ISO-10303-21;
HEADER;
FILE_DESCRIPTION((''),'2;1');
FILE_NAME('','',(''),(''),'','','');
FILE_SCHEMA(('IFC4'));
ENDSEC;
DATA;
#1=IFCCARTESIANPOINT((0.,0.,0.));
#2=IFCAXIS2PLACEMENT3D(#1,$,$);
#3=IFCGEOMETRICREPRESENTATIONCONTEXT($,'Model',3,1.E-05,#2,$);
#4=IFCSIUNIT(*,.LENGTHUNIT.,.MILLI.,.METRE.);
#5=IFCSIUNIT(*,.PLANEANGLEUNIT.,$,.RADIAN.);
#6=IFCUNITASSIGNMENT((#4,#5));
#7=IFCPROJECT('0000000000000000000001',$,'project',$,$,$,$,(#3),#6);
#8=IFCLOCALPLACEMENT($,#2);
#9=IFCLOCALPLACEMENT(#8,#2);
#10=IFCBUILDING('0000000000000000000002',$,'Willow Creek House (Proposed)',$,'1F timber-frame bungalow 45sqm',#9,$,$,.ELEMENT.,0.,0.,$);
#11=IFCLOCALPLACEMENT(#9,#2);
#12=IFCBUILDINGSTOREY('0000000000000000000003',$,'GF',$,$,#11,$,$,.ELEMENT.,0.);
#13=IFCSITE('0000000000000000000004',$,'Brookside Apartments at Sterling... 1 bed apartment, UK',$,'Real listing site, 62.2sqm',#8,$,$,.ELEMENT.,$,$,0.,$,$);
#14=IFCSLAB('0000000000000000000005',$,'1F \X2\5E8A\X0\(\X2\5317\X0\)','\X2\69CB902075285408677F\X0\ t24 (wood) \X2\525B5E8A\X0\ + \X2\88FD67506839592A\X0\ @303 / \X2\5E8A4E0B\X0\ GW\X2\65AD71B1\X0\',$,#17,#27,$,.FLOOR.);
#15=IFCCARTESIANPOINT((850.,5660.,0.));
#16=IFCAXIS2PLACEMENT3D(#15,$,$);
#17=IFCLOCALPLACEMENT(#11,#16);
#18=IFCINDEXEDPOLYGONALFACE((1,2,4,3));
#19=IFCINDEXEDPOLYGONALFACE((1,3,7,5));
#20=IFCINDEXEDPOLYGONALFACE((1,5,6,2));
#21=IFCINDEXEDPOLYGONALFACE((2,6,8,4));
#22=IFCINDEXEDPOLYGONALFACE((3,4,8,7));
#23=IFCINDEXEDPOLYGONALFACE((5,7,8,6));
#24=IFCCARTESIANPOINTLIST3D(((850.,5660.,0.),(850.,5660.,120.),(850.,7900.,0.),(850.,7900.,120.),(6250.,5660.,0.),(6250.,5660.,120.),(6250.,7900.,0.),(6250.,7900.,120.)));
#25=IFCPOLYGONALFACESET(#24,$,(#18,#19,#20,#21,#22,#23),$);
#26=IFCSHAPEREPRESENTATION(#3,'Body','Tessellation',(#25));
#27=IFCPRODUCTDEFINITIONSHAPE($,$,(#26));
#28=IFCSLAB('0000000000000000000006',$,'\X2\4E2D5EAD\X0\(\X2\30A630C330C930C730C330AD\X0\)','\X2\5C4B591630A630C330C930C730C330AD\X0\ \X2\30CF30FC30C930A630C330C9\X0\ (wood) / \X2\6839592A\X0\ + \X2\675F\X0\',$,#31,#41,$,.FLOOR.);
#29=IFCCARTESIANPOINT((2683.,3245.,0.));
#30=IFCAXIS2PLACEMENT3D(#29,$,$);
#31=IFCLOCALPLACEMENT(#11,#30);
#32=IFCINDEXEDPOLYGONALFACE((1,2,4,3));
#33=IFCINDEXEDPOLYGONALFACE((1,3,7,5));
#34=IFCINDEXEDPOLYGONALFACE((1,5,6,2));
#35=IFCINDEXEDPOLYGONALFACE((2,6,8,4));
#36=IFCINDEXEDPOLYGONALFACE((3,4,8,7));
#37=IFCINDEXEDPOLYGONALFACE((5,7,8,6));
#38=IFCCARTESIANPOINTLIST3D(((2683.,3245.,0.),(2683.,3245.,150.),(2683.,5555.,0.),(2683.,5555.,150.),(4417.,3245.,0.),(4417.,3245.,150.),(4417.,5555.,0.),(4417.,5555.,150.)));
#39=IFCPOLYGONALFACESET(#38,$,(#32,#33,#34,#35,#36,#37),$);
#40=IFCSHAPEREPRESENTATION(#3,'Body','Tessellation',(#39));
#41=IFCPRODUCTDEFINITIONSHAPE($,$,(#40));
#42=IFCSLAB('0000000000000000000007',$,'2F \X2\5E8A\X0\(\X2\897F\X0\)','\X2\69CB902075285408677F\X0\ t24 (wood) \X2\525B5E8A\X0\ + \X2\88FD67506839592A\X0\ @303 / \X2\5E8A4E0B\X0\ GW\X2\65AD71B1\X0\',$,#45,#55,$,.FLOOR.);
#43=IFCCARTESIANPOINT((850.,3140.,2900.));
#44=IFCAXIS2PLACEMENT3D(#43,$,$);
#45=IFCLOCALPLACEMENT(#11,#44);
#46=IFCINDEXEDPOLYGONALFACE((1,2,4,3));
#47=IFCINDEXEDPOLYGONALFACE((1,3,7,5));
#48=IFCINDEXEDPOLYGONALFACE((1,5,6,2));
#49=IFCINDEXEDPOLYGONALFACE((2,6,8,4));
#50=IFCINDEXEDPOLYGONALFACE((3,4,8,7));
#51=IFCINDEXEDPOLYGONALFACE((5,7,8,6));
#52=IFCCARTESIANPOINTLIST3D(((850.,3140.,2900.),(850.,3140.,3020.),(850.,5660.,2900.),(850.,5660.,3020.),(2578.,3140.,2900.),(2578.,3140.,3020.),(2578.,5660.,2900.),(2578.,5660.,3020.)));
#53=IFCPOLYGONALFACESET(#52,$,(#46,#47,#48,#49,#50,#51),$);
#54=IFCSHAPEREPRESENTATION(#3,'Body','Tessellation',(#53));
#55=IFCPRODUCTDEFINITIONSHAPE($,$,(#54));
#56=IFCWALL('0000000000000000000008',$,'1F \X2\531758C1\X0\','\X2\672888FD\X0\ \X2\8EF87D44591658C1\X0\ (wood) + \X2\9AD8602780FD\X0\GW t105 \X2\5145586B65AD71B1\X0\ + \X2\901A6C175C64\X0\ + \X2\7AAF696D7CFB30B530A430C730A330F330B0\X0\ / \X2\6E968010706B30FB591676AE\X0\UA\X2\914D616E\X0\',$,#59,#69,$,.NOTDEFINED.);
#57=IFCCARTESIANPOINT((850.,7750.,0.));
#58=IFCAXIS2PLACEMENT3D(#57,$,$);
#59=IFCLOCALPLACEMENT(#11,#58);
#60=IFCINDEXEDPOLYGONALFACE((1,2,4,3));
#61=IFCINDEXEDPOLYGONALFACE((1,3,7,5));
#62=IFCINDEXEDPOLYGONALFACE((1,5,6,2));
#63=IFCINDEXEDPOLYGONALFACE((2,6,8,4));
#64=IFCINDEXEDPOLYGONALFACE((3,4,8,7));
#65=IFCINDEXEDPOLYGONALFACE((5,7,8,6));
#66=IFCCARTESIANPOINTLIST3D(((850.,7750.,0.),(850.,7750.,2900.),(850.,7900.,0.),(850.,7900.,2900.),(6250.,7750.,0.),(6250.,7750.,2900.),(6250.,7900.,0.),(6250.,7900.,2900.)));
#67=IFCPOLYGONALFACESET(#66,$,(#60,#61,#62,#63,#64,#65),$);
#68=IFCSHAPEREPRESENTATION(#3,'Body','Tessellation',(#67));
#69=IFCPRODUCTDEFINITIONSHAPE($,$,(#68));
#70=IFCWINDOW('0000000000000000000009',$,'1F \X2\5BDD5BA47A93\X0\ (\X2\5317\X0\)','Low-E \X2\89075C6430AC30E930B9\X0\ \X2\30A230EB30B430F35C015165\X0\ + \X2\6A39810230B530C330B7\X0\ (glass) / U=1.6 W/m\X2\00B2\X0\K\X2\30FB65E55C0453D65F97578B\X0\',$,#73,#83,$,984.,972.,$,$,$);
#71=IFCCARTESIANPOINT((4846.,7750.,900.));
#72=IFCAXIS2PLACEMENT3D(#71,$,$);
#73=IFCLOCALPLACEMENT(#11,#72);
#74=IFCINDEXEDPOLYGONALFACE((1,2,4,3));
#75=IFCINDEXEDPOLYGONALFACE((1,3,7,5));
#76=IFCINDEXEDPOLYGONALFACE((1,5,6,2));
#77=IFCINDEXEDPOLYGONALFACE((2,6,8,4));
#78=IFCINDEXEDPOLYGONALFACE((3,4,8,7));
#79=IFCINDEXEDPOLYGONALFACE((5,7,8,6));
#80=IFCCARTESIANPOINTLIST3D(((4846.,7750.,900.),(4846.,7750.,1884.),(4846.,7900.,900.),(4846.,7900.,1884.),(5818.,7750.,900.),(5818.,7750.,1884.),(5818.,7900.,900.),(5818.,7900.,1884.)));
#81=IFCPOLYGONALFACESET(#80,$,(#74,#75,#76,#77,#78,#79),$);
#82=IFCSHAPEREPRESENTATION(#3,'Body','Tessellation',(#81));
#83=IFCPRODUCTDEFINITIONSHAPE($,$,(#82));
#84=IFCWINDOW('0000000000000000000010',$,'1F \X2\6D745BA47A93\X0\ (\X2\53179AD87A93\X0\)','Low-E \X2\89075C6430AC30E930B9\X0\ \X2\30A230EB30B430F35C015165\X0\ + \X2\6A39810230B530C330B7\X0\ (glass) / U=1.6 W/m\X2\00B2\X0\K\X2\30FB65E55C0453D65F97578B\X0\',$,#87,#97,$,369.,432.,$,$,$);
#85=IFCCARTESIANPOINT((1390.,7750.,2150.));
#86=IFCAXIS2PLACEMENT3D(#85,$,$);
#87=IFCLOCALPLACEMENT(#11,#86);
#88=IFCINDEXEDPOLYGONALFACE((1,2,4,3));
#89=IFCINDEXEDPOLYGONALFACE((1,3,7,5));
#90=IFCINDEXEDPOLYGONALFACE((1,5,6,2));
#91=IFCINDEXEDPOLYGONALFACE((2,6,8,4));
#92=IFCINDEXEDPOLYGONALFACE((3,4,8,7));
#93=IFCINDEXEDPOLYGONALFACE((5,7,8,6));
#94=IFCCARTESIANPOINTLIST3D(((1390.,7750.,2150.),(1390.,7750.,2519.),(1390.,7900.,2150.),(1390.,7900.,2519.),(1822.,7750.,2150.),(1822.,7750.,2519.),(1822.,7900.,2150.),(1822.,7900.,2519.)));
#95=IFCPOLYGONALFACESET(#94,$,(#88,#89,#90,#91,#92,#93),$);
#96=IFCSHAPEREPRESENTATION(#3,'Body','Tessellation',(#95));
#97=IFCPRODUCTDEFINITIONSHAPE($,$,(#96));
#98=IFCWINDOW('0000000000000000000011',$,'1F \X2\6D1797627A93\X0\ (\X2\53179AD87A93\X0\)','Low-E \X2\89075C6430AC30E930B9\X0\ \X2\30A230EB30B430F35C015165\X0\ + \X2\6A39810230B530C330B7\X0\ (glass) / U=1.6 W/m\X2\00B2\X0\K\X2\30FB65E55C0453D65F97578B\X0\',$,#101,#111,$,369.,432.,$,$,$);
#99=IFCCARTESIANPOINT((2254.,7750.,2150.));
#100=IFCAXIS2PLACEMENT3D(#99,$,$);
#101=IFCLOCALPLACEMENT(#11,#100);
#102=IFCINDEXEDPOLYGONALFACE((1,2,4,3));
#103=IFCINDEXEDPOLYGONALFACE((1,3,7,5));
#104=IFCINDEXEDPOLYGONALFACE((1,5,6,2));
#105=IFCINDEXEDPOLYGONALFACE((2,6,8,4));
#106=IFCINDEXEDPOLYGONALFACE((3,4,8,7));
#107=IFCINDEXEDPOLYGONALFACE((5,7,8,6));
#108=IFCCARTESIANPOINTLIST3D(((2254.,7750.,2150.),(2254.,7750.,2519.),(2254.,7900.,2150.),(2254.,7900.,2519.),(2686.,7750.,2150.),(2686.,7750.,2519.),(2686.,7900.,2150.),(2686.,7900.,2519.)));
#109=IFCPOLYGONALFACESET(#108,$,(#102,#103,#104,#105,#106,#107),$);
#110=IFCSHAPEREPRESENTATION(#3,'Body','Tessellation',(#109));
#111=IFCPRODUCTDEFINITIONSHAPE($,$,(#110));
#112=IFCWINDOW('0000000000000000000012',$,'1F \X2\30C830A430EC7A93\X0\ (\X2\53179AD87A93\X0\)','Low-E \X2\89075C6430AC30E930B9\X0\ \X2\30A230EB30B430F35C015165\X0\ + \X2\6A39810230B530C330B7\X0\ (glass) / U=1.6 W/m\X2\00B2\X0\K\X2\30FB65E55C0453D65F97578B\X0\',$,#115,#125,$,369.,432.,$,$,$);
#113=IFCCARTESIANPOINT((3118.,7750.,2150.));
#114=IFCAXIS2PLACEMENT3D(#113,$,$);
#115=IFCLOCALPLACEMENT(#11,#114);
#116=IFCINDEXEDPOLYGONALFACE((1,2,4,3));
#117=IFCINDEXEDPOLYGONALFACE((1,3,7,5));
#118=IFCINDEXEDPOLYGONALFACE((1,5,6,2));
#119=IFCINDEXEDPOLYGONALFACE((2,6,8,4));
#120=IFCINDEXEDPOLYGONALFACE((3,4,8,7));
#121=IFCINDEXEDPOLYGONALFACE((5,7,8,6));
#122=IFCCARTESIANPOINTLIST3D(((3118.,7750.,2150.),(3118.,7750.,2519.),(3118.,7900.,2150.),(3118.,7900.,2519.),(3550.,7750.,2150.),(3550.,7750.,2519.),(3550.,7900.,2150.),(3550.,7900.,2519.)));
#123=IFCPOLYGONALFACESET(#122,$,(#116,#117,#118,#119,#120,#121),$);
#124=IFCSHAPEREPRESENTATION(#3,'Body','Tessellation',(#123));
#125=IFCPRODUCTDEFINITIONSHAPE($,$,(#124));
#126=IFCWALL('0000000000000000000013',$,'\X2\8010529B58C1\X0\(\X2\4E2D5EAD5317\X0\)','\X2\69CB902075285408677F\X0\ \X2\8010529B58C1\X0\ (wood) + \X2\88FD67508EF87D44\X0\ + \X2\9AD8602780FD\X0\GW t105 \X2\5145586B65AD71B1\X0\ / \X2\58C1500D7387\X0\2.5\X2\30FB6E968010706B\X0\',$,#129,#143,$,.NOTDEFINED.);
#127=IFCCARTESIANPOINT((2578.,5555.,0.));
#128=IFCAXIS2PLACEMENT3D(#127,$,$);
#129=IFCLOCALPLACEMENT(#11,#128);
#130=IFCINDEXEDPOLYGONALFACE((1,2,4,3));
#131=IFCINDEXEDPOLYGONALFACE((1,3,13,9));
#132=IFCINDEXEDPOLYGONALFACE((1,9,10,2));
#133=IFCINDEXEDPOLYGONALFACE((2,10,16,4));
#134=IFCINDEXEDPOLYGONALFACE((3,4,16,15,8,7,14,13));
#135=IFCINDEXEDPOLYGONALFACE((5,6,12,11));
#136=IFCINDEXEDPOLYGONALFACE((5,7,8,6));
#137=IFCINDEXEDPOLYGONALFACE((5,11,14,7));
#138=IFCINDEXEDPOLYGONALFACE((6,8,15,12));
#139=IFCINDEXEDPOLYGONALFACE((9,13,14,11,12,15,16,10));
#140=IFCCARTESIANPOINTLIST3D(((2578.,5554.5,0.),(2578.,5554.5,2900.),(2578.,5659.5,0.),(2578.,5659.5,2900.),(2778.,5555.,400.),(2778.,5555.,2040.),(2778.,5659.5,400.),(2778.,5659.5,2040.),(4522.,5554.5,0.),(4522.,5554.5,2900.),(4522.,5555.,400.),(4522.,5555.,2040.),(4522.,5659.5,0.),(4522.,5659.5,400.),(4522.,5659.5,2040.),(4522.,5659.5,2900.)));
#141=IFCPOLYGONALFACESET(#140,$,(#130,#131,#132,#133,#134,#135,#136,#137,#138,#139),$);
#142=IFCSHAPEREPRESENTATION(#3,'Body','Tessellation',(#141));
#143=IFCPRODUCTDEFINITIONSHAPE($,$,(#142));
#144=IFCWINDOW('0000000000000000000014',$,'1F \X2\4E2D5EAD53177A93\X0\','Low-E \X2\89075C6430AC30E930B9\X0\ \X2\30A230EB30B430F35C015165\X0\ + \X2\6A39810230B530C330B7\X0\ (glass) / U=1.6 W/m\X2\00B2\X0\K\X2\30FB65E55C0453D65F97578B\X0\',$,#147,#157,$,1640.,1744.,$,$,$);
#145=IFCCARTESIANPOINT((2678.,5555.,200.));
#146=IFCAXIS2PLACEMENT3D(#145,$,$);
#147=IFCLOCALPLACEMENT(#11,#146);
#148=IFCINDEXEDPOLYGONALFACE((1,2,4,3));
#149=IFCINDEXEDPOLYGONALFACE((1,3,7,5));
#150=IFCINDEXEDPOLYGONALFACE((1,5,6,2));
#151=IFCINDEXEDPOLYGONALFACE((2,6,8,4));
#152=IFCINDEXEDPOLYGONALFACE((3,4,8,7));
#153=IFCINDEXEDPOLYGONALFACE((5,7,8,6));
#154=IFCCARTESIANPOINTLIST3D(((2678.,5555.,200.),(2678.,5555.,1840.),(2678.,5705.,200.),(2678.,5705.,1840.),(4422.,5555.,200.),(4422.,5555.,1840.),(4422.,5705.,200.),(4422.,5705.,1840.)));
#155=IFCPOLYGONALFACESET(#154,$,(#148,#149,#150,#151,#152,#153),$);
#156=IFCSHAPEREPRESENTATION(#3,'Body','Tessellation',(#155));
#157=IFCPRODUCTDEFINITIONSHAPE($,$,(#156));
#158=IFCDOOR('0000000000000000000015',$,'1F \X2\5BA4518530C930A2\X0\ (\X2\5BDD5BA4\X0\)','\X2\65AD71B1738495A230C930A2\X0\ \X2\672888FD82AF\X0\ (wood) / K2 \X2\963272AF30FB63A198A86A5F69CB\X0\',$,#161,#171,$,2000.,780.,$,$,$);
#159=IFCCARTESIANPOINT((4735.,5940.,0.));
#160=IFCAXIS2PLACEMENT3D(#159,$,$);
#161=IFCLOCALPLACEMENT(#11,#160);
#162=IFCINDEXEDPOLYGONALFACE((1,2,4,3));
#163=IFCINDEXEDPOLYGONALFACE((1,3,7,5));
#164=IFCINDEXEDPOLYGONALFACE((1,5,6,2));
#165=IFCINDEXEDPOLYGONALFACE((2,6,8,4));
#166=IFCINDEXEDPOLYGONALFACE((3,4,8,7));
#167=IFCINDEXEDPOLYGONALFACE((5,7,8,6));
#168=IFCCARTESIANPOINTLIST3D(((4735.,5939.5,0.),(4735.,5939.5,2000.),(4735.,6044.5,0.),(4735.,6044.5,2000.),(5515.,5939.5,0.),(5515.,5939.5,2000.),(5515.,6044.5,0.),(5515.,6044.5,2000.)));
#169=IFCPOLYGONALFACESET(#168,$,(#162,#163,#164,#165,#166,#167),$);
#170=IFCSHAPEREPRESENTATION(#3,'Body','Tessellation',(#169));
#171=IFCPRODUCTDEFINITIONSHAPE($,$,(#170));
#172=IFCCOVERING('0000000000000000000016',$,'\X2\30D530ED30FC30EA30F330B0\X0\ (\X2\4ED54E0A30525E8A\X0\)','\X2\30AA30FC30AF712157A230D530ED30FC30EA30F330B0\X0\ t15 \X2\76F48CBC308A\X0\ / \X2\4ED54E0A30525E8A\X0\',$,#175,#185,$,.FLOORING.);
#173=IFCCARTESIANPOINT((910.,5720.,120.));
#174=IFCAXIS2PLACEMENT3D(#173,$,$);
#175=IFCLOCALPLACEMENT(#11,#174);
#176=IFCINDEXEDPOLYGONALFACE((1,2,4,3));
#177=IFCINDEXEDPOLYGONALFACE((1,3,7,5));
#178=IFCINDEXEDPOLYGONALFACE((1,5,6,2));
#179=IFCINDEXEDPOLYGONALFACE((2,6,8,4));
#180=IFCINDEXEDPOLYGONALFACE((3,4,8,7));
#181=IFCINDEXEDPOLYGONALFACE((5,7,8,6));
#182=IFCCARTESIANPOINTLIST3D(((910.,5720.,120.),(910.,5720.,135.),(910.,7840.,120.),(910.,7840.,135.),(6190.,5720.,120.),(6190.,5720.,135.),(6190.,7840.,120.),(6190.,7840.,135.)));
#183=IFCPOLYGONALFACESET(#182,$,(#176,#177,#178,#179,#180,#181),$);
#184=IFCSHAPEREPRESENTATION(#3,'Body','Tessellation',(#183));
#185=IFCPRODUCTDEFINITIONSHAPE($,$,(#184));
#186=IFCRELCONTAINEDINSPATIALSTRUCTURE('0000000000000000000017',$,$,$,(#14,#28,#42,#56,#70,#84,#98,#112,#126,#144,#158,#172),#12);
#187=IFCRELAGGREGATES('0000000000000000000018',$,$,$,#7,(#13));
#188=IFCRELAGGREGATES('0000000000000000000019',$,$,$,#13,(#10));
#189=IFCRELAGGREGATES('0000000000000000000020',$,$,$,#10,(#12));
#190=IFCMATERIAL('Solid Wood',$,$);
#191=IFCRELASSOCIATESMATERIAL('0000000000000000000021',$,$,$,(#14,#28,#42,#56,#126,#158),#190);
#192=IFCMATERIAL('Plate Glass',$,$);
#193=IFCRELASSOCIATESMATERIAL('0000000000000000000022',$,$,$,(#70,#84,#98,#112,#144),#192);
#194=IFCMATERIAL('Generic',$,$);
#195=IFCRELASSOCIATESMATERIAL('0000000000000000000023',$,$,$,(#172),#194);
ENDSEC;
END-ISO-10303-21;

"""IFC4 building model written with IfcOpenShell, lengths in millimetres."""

from ifc_helpers import new_model, si_unit, frame, frame_2d, origin, place, context, project, spatial, rectangle, extrude, material, element, fill, save


model = new_model("IFC4")

# Units and contexts
model_context = context("Model", 3, precision=1e-05, world=origin())
ifc_project = project(units=[si_unit("LENGTHUNIT", "METRE", prefix="MILLI"), si_unit("PLANEANGLEUNIT", "RADIAN")], contexts=[model_context])

# Site, building, storey
site_placement = place(None, origin())
site = spatial("IfcSite", under=ifc_project, at=site_placement, Name="Brookside Apartments at Sterling... 1 bed apartment, UK", ObjectType="Real listing site, 62.2sqm", CompositionType="ELEMENT", RefElevation=0.0)
building_placement = place(site_placement, origin())
building = spatial("IfcBuilding", under=site, at=building_placement, Name="Willow Creek House (Proposed)", ObjectType="1F timber-frame bungalow 45sqm", CompositionType="ELEMENT", ElevationOfRefHeight=0.0, ElevationOfTerrain=0.0)
storey_placement = place(building_placement, origin())
storey = spatial("IfcBuildingStorey", under=building, at=storey_placement, Name="GF", CompositionType="ELEMENT", Elevation=0.0)

# Slabs
ifc_material_1 = material(Name="Solid Wood")
slab_1_placement = place(storey_placement, frame((850.0, 5660.0, 0.0)))
element("IfcSlab", 1, at=slab_1_placement, inside=storey, material=ifc_material_1, Name="1F 床(北)", Description="構造用合板 t24 (wood) 剛床 + 製材根太 @303 / 床下 GW断熱", PredefinedType="FLOOR", context=model_context, shape_type="SweptSolid", body=[
    extrude(rectangle(XDim=5400.0, YDim=2240.0, at=frame_2d((2700.0, 1120.0))), frame((850.0, 5660.0, 0.0)), (0.0, 0.0, 1.0), 120.0),
])
slab_2_placement = place(storey_placement, frame((2683.0, 3245.0, 0.0)))
element("IfcSlab", 2, at=slab_2_placement, inside=storey, material=ifc_material_1, Name="中庭(ウッドデッキ)", Description="屋外ウッドデッキ ハードウッド (wood) / 根太 + 束", PredefinedType="FLOOR", context=model_context, shape_type="SweptSolid", body=[
    extrude(rectangle(XDim=1734.0, YDim=2310.0, at=frame_2d((867.0, 1155.0))), frame((2683.0, 3245.0, 0.0)), (0.0, 0.0, 1.0), 150.0),
])
slab_3_placement = place(storey_placement, frame((850.0, 3140.0, 2900.0)))
element("IfcSlab", 3, at=slab_3_placement, inside=storey, material=ifc_material_1, Name="2F 床(西)", Description="構造用合板 t24 (wood) 剛床 + 製材根太 @303 / 床下 GW断熱", PredefinedType="FLOOR", context=model_context, shape_type="SweptSolid", body=[
    extrude(rectangle(XDim=1728.0, YDim=2520.0, at=frame_2d((864.0, 1260.0))), frame((850.0, 3140.0, 2900.0)), (0.0, 0.0, 1.0), 120.0),
])

# Wall, openings, windows
wall_1_placement = place(storey_placement, frame((850.0, 7750.0, 0.0)))
wall_1 = element("IfcWall", 4, at=wall_1_placement, inside=storey, material=ifc_material_1, Name="1F 北壁", Description="木製 軸組外壁 (wood) + 高性能GW t105 充填断熱 + 通気層 + 窯業系サイディング / 準耐火・外皮UA配慮", PredefinedType="NOTDEFINED", context=model_context, shape_type="SweptSolid", body=[
    extrude(rectangle(XDim=5400.0, YDim=150.0, at=frame_2d((2700.0, 75.0))), frame((850.0, 7750.0, 0.0)), (0.0, 0.0, 1.0), 2900.0),
])
opening_1_placement = place(storey_placement, frame((4846.0, 7750.0, 900.0)))
opening_1 = element("IfcOpeningElement", 5, at=opening_1_placement, cuts=wall_1, PredefinedType="NOTDEFINED", context=model_context, shape_type="SweptSolid", body=[
    extrude(rectangle(XDim=972.0, YDim=150.0, at=frame_2d((486.0, 75.0))), frame((4846.0, 7750.0, 900.0)), (0.0, 0.0, 1.0), 984.0),
])
opening_2_placement = place(storey_placement, frame((1390.0, 7750.0, 2150.0)))
opening_2 = element("IfcOpeningElement", 6, at=opening_2_placement, cuts=wall_1, PredefinedType="NOTDEFINED", context=model_context, shape_type="SweptSolid", body=[
    extrude(rectangle(XDim=432.0, YDim=150.0, at=frame_2d((216.0, 75.0))), frame((1390.0, 7750.0, 2150.0)), (0.0, 0.0, 1.0), 369.0),
])
opening_3_placement = place(storey_placement, frame((2254.0, 7750.0, 2150.0)))
opening_3 = element("IfcOpeningElement", 7, at=opening_3_placement, cuts=wall_1, PredefinedType="NOTDEFINED", context=model_context, shape_type="SweptSolid", body=[
    extrude(rectangle(XDim=432.0, YDim=150.0, at=frame_2d((216.0, 75.0))), frame((2254.0, 7750.0, 2150.0)), (0.0, 0.0, 1.0), 369.0),
])
opening_4_placement = place(storey_placement, frame((3118.0, 7750.0, 2150.0)))
opening_4 = element("IfcOpeningElement", 8, at=opening_4_placement, cuts=wall_1, PredefinedType="NOTDEFINED", context=model_context, shape_type="SweptSolid", body=[
    extrude(rectangle(XDim=432.0, YDim=150.0, at=frame_2d((216.0, 75.0))), frame((3118.0, 7750.0, 2150.0)), (0.0, 0.0, 1.0), 369.0),
])
ifc_material_2 = material(Name="Plate Glass")
window_1_placement = place(storey_placement, frame((4846.0, 7750.0, 900.0)))
window_1 = element("IfcWindow", 9, at=window_1_placement, inside=storey, material=ifc_material_2, Name="1F 寝室窓 (北)", Description="Low-E 複層ガラス アルゴン封入 + 樹脂サッシ (glass) / U=1.6 W/m²K・日射取得型", OverallHeight=984.0, OverallWidth=972.0, context=model_context, shape_type="SweptSolid", body=[
    extrude(rectangle(XDim=972.0, YDim=150.0, at=frame_2d((486.0, 75.0))), frame((4846.0, 7750.0, 900.0)), (0.0, 0.0, 1.0), 984.0),
])
fill(opening_1, window_1)
window_2_placement = place(storey_placement, frame((1390.0, 7750.0, 2150.0)))
window_2 = element("IfcWindow", 10, at=window_2_placement, inside=storey, material=ifc_material_2, Name="1F 浴室窓 (北高窓)", Description="Low-E 複層ガラス アルゴン封入 + 樹脂サッシ (glass) / U=1.6 W/m²K・日射取得型", OverallHeight=369.0, OverallWidth=432.0, context=model_context, shape_type="SweptSolid", body=[
    extrude(rectangle(XDim=432.0, YDim=150.0, at=frame_2d((216.0, 75.0))), frame((1390.0, 7750.0, 2150.0)), (0.0, 0.0, 1.0), 369.0),
])
fill(opening_2, window_2)
window_3_placement = place(storey_placement, frame((2254.0, 7750.0, 2150.0)))
window_3 = element("IfcWindow", 11, at=window_3_placement, inside=storey, material=ifc_material_2, Name="1F 洗面窓 (北高窓)", Description="Low-E 複層ガラス アルゴン封入 + 樹脂サッシ (glass) / U=1.6 W/m²K・日射取得型", OverallHeight=369.0, OverallWidth=432.0, context=model_context, shape_type="SweptSolid", body=[
    extrude(rectangle(XDim=432.0, YDim=150.0, at=frame_2d((216.0, 75.0))), frame((2254.0, 7750.0, 2150.0)), (0.0, 0.0, 1.0), 369.0),
])
fill(opening_3, window_3)
window_4_placement = place(storey_placement, frame((3118.0, 7750.0, 2150.0)))
window_4 = element("IfcWindow", 12, at=window_4_placement, inside=storey, material=ifc_material_2, Name="1F トイレ窓 (北高窓)", Description="Low-E 複層ガラス アルゴン封入 + 樹脂サッシ (glass) / U=1.6 W/m²K・日射取得型", OverallHeight=369.0, OverallWidth=432.0, context=model_context, shape_type="SweptSolid", body=[
    extrude(rectangle(XDim=432.0, YDim=150.0, at=frame_2d((216.0, 75.0))), frame((3118.0, 7750.0, 2150.0)), (0.0, 0.0, 1.0), 369.0),
])
fill(opening_4, window_4)

# Wall, opening, window
wall_2_placement = place(storey_placement, frame((2578.0, 5555.0, 0.0)))
wall_2 = element("IfcWall", 13, at=wall_2_placement, inside=storey, material=ifc_material_1, Name="耐力壁(中庭北)", Description="構造用合板 耐力壁 (wood) + 製材軸組 + 高性能GW t105 充填断熱 / 壁倍率2.5・準耐火", PredefinedType="NOTDEFINED", context=model_context, shape_type="SweptSolid", body=[
    extrude(rectangle(XDim=1944.0, YDim=105.0, at=frame_2d((972.0, 52.0))), frame((2578.0, 5555.0, 0.0)), (0.0, 0.0, 1.0), 2900.0),
])
opening_5_placement = place(storey_placement, frame((2678.0, 5555.0, 200.0)))
opening_5 = element("IfcOpeningElement", 14, at=opening_5_placement, cuts=wall_2, PredefinedType="NOTDEFINED", context=model_context, shape_type="SweptSolid", body=[
    extrude(rectangle(XDim=1744.0, YDim=150.0, at=frame_2d((872.0, 75.0))), frame((2678.0, 5555.0, 200.0)), (0.0, 0.0, 1.0), 1640.0),
])
window_5_placement = place(storey_placement, frame((2678.0, 5555.0, 200.0)))
window_5 = element("IfcWindow", 15, at=window_5_placement, inside=storey, material=ifc_material_2, Name="1F 中庭北窓", Description="Low-E 複層ガラス アルゴン封入 + 樹脂サッシ (glass) / U=1.6 W/m²K・日射取得型", OverallHeight=1640.0, OverallWidth=1744.0, context=model_context, shape_type="SweptSolid", body=[
    extrude(rectangle(XDim=1744.0, YDim=150.0, at=frame_2d((872.0, 75.0))), frame((2678.0, 5555.0, 200.0)), (0.0, 0.0, 1.0), 1640.0),
])
fill(opening_5, window_5)

# Door
door_1_placement = place(storey_placement, frame((4735.0, 5940.0, 0.0)))
element("IfcDoor", 16, at=door_1_placement, inside=storey, material=ifc_material_1, Name="1F 室内ドア (寝室)", Description="断熱玄関ドア 木製芯 (wood) / K2 防犯・採風機構", OverallHeight=2000.0, OverallWidth=780.0, context=model_context, shape_type="SweptSolid", body=[
    extrude(rectangle(XDim=780.0, YDim=105.0, at=frame_2d((390.0, 52.0))), frame((4735.0, 5940.0, 0.0)), (0.0, 0.0, 1.0), 2000.0),
])

# Covering
ifc_material_3 = material(Name="Generic")
covering_1_placement = place(storey_placement, frame((910.0, 5720.0, 120.0)))
element("IfcCovering", 17, at=covering_1_placement, inside=storey, material=ifc_material_3, Name="フローリング (仕上げ床)", Description="オーク無垢フローリング t15 直貼り / 仕上げ床", PredefinedType="FLOORING", context=model_context, shape_type="SweptSolid", body=[
    extrude(rectangle(XDim=5280.0, YDim=2120.0, at=frame_2d((2640.0, 1060.0))), frame((910.0, 5720.0, 120.0)), (0.0, 0.0, 1.0), 15.0),
])

save(model, "model.ifc")
